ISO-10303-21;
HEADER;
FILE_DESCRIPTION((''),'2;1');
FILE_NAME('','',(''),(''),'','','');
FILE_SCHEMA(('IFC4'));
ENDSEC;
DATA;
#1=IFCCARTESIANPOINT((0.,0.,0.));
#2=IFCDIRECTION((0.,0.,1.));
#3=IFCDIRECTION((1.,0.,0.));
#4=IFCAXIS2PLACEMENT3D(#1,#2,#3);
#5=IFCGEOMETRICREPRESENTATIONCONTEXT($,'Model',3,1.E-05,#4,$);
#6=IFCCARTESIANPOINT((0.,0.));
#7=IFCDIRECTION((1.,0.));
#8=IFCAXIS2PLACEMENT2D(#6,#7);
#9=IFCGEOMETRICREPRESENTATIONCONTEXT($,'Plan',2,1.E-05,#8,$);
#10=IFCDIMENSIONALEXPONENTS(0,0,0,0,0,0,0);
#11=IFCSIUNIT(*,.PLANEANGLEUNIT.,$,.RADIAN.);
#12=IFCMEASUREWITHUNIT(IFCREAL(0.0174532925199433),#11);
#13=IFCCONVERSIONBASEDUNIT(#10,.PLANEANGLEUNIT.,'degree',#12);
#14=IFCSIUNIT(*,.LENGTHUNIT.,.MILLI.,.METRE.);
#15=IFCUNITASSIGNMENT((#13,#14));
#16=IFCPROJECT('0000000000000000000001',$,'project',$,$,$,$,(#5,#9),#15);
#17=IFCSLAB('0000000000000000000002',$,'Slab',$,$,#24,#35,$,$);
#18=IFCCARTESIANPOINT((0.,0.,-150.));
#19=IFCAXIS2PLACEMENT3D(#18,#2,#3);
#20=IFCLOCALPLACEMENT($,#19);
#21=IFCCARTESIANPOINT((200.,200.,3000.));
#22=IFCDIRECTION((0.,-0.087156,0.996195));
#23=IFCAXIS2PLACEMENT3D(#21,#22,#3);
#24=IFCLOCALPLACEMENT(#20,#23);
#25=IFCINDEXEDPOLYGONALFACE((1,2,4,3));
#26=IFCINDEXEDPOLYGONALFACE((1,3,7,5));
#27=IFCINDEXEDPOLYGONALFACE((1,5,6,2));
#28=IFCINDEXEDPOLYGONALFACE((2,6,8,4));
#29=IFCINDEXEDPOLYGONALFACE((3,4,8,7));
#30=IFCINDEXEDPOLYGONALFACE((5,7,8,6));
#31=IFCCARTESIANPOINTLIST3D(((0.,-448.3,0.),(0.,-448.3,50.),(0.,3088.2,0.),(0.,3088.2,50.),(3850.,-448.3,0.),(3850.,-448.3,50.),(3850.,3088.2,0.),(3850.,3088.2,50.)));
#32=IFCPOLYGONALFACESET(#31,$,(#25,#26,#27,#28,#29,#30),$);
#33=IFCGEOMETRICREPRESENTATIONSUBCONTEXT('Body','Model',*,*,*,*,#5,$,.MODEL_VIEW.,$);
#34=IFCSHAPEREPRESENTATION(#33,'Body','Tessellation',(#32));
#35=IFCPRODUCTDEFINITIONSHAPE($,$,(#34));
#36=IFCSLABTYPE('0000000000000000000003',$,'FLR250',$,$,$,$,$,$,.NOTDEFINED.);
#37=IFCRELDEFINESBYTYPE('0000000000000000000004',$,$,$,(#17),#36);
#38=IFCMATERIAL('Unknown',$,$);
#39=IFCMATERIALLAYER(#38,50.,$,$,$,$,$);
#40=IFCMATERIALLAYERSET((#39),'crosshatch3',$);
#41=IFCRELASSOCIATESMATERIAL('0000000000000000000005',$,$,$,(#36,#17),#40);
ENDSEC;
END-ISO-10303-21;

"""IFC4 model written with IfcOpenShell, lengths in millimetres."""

from ifc_helpers import new_model, entity, si_unit, converted_unit, frame, origin_with_axes, origin_2d_with_axis, place, context, subcontext, project, line, indexed_curve, outline, extrude, material, layer, layer_set, layer_usage, type_object, element, save


model = new_model("IFC4")

# Units and contexts
model_context = context("Model", 3, precision=1e-05, world=origin_with_axes())
plan_context = context("Plan", 2, precision=1e-05, world=origin_2d_with_axis())
body_context = subcontext(model_context, "Body", "Model", "MODEL_VIEW")
ifc_project = project(units=[converted_unit("PLANEANGLEUNIT", "degree", entity("IfcReal", 0.0174532925199433), si_unit("PLANEANGLEUNIT", "RADIAN"), dimensions=[0, 0, 0, 0, 0, 0, 0]), si_unit("LENGTHUNIT", "METRE", prefix="MILLI")], contexts=[model_context, plan_context])

# Shared definitions
ifc_material = material(Name="Unknown")
placement = place(None, frame((0.0, 0.0, -150.0), z_axis=(0.0, 0.0, 1.0), x_axis=(1.0, 0.0, 0.0)))

# Slab
ifc_layer_1 = layer(ifc_material, 50.0)
ifc_layer_set_1 = layer_set([ifc_layer_1], Name="crosshatch3")
ifc_layer_usage_1 = layer_usage(ifc_layer_set_1, "AXIS3", "POSITIVE", 0.0)
slab_type_1 = type_object("IfcSlabType", Name="FLR250", PredefinedType="NOTDEFINED", material=ifc_layer_set_1)
slab_1_placement = place(placement, frame((200.0, 200.0, 3000.0), z_axis=(0.0, -0.087156, 0.996195), x_axis=(1.0, 0.0, 0.0)))
element("IfcSlab", 1, at=slab_1_placement, type_object=slab_type_1, material=ifc_layer_usage_1, Name="Slab", context=body_context, shape_type="SweptSolid", body=[
    extrude(outline(indexed_curve([(0.0, -448.3), (3850.0, -448.3), (3850.0, 3088.2), (0.0, 3088.2)], segments=[line(3, 2), line(2, 1), line(1, 4), line(4, 3)], self_intersect=False)), None, (0.0, 0.0, 1.0), 50.0),
])

save(model, "model.ifc")
